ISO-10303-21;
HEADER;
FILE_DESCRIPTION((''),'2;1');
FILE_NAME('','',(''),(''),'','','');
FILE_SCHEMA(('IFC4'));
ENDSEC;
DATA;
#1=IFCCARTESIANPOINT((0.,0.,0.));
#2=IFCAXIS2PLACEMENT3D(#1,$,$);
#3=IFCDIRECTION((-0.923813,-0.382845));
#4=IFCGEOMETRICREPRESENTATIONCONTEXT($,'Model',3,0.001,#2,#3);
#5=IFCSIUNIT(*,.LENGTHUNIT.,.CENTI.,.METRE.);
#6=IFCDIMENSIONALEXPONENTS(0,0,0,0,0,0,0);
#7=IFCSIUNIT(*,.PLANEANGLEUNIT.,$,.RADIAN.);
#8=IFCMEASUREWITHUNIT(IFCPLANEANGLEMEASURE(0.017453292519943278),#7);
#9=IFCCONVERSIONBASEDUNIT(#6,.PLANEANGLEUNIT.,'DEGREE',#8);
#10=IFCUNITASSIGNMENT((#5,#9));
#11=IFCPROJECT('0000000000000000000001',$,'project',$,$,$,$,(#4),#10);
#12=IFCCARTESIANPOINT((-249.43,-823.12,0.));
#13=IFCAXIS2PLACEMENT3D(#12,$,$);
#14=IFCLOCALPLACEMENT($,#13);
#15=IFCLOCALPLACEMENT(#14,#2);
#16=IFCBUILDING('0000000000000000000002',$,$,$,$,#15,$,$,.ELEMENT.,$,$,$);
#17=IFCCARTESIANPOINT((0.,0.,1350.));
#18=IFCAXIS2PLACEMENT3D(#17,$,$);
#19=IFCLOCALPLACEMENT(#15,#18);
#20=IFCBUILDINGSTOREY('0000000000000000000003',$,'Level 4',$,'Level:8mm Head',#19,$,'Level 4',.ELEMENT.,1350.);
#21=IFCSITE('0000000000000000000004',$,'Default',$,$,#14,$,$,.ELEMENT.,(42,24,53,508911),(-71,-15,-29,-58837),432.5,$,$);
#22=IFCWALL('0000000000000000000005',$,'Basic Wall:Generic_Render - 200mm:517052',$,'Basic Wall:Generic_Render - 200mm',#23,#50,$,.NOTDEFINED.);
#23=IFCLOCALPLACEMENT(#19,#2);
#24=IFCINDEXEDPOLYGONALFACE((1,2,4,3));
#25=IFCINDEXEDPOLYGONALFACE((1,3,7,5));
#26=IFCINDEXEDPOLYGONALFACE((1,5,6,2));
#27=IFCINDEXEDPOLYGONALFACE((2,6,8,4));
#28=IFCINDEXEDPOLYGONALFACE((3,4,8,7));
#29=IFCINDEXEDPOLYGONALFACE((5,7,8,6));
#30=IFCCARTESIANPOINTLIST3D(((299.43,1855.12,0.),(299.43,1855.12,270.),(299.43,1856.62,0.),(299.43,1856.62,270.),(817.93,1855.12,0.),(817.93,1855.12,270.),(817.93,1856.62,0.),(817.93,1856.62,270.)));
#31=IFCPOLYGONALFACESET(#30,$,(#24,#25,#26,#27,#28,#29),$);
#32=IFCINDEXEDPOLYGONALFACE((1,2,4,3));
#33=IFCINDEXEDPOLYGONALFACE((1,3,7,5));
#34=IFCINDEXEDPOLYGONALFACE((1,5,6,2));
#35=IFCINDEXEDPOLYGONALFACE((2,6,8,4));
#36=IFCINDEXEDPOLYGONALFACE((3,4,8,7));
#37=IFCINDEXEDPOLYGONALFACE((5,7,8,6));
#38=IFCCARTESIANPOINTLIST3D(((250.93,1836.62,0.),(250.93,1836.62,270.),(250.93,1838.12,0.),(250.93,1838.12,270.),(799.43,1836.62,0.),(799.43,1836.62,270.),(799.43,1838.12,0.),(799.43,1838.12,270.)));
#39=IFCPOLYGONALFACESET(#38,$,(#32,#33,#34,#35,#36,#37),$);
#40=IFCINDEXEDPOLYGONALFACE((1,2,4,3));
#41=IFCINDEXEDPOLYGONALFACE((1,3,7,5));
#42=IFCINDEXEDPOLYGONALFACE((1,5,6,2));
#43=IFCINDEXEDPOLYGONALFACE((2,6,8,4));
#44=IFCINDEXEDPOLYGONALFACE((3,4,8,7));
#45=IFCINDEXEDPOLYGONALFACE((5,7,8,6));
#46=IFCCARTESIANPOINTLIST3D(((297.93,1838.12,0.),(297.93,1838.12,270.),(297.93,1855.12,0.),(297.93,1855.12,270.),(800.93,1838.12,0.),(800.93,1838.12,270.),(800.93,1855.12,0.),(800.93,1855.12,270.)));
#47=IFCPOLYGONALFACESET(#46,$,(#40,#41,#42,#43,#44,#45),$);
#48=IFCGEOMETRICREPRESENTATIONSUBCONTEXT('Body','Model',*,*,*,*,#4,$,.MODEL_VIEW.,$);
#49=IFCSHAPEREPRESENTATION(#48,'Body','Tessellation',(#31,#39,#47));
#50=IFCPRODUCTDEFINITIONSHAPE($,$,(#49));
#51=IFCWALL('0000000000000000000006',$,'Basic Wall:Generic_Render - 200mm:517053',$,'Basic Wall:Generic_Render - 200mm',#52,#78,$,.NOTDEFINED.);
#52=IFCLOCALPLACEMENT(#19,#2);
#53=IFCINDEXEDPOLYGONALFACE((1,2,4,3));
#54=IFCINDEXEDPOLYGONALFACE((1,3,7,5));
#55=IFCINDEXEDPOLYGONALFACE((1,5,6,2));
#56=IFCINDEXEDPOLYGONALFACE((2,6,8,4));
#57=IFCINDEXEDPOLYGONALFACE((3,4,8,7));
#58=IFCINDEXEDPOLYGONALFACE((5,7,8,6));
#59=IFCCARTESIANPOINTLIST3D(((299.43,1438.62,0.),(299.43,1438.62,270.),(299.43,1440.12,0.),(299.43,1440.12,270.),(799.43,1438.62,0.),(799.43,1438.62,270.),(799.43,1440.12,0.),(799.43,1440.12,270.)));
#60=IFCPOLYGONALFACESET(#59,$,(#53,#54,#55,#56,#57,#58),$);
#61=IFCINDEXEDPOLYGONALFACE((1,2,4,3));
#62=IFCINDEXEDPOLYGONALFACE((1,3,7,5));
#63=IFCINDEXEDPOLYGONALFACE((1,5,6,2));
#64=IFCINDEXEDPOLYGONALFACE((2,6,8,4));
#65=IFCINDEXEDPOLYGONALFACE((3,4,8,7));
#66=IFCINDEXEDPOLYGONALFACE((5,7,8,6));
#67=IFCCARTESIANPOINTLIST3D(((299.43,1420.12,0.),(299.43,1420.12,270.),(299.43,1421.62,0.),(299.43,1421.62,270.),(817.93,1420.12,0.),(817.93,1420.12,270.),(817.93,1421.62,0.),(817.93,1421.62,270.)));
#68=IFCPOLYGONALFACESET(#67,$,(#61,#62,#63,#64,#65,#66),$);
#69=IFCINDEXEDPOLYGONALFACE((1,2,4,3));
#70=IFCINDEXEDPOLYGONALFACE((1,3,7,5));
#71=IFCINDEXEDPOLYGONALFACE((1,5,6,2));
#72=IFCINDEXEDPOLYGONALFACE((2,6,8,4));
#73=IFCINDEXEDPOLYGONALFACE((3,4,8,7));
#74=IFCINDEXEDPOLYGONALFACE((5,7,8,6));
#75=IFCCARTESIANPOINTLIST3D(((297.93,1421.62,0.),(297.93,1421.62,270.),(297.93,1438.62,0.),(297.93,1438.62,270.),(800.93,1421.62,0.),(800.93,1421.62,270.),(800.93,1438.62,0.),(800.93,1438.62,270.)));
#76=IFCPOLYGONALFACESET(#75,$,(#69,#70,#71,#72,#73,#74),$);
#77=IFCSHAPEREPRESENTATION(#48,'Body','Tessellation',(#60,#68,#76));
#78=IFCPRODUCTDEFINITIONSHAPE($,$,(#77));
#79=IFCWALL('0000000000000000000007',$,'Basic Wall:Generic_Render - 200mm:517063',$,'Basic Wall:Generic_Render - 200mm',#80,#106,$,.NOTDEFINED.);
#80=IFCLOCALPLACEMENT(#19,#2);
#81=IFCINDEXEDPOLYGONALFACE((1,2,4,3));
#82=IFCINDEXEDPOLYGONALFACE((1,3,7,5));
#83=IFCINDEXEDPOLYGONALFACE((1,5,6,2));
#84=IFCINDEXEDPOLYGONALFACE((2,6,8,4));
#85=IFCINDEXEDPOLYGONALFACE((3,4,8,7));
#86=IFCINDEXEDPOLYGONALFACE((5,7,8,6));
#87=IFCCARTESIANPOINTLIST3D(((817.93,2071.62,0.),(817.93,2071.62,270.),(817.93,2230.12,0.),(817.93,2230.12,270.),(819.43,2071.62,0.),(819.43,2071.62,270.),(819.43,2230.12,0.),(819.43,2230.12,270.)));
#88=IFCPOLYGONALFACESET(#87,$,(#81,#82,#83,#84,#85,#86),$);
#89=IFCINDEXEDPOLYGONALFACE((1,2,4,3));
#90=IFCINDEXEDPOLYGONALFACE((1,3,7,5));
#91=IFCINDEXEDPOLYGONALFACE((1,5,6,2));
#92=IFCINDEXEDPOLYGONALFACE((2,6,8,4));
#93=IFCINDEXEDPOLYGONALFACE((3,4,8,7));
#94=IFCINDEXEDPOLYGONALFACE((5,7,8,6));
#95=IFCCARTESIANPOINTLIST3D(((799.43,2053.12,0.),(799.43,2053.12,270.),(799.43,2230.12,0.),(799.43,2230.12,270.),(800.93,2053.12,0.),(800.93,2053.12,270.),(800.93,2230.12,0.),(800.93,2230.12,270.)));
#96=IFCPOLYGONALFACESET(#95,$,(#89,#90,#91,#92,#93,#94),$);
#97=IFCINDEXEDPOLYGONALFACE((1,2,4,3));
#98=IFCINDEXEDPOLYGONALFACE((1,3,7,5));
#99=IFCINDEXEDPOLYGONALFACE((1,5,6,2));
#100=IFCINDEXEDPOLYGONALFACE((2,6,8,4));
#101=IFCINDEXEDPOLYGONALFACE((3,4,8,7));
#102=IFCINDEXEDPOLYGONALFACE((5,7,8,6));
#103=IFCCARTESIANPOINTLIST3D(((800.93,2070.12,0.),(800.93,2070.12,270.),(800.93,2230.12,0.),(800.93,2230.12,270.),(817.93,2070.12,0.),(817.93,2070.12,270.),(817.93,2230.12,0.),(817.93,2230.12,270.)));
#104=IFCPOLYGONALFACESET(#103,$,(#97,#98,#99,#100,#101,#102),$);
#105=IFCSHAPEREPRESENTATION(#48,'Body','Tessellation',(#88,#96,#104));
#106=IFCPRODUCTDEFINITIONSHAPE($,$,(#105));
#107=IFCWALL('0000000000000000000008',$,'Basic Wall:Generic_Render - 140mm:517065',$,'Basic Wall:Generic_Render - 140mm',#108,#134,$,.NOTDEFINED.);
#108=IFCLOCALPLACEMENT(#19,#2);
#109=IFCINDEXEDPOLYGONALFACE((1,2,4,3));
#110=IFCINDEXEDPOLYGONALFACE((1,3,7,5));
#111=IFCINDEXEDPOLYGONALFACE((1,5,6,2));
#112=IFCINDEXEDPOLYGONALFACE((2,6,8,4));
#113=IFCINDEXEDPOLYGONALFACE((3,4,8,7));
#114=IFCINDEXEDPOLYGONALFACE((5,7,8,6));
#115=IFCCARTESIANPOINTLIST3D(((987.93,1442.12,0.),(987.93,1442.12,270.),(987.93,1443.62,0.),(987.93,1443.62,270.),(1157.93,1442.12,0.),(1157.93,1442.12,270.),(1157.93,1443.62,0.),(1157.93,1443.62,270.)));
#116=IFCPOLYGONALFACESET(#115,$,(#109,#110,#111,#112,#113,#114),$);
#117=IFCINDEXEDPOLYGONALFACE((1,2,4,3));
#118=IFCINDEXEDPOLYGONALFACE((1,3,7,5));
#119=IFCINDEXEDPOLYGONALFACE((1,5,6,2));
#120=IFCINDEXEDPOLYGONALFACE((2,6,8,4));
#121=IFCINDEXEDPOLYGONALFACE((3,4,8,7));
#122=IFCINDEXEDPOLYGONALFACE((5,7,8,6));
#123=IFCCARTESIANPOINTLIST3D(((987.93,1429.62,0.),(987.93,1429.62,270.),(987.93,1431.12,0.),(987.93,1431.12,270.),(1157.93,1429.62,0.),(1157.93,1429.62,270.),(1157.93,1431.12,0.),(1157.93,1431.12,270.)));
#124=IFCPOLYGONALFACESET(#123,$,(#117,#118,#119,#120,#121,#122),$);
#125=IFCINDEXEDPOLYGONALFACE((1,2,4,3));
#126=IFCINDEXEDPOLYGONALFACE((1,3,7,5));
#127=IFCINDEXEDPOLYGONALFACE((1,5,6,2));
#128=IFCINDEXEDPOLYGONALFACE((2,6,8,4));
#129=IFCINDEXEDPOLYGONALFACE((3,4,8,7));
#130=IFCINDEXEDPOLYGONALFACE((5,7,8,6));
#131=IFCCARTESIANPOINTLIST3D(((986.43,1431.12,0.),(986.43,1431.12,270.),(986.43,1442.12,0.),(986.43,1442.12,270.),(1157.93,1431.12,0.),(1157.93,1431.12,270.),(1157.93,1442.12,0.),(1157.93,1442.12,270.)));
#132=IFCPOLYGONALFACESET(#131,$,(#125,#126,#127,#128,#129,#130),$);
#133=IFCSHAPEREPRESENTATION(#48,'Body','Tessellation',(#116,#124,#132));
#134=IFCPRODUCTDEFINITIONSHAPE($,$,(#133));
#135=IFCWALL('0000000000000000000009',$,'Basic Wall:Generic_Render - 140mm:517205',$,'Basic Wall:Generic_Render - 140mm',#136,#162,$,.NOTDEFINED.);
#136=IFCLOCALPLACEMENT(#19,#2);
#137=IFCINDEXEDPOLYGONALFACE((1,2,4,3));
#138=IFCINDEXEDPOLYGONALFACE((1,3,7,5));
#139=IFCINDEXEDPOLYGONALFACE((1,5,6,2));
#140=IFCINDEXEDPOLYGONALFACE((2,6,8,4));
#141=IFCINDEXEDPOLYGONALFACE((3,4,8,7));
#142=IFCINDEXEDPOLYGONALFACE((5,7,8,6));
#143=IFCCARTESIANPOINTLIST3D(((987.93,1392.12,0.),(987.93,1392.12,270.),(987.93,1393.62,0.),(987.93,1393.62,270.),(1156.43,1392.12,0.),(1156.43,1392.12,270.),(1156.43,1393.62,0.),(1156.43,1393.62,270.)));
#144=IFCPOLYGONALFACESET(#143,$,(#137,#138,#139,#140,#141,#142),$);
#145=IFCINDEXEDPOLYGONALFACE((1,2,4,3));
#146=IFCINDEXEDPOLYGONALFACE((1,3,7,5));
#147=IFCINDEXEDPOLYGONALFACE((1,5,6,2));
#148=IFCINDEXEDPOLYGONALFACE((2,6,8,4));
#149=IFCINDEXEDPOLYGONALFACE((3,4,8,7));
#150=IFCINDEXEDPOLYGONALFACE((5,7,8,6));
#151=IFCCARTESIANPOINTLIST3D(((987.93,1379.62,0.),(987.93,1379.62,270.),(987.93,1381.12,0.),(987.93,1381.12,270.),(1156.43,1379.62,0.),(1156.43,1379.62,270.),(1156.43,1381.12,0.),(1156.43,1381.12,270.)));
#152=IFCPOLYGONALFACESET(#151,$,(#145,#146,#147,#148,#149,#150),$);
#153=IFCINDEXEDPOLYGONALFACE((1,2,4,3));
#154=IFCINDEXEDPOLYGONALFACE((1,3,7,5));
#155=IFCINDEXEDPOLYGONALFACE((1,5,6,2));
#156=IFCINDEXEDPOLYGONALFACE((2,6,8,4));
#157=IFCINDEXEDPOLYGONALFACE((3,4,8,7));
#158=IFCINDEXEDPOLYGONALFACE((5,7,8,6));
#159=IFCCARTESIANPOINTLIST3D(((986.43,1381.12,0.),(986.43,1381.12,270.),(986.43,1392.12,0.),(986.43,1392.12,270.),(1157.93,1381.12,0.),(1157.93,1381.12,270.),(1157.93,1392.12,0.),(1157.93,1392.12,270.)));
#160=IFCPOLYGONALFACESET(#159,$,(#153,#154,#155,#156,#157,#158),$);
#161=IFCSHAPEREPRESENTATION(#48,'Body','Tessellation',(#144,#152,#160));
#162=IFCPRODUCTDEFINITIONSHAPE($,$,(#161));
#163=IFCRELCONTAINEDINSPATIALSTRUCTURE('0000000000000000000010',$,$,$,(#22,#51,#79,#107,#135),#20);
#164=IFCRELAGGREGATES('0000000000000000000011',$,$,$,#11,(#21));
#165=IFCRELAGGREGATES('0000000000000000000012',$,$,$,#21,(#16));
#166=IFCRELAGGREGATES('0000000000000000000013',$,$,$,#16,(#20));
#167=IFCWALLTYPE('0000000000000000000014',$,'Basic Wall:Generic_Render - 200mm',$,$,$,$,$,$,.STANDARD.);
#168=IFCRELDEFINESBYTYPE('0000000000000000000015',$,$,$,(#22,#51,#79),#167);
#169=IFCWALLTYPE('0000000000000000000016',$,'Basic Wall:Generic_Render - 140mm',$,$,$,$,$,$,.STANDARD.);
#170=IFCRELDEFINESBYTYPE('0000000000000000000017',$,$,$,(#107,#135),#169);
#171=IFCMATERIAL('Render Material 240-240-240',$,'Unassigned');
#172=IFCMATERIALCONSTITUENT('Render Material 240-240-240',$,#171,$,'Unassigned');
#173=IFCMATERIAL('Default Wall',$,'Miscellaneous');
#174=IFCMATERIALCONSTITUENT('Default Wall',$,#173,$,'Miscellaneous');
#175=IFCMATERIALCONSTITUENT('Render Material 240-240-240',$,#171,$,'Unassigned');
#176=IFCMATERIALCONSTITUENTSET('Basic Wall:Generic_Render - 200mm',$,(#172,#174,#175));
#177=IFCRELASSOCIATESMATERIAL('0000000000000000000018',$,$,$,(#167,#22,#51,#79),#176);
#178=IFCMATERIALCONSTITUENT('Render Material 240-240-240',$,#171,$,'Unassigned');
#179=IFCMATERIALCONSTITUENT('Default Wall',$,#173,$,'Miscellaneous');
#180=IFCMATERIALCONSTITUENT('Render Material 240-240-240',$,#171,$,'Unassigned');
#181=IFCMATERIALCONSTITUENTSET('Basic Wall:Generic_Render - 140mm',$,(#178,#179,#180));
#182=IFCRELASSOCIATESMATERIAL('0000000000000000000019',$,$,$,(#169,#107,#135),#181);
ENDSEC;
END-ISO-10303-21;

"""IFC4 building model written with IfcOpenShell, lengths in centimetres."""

from ifc_helpers import new_model, entity, si_unit, converted_unit, direction, frame, origin, place, context, subcontext, project, spatial, indexed_curve, outline, extrude, material, constituent, constituent_set, type_object, element, save


model = new_model("IFC4")

# Units and contexts
model_context = context("Model", 3, precision=0.001, world=origin(), true_north=direction((-0.923813, -0.382845)))
body_context = subcontext(model_context, "Body", "Model", "MODEL_VIEW")
ifc_project = project(units=[si_unit("LENGTHUNIT", "METRE", prefix="CENTI"), converted_unit("PLANEANGLEUNIT", "DEGREE", entity("IfcPlaneAngleMeasure", 0.017453292519943278), si_unit("PLANEANGLEUNIT", "RADIAN"), dimensions=[0, 0, 0, 0, 0, 0, 0])], contexts=[model_context])

# Site, building, storey
site_placement = place(None, frame((-249.43, -823.12, 0.0)))
site = spatial("IfcSite", under=ifc_project, at=site_placement, Name="Default", CompositionType="ELEMENT", RefLatitude=(42, 24, 53, 508911), RefLongitude=(-71, -15, -29, -58837), RefElevation=432.5)
building_placement = place(site_placement, origin())
building = spatial("IfcBuilding", under=site, at=building_placement, CompositionType="ELEMENT")
storey_placement = place(building_placement, frame((0.0, 0.0, 1350.0)))
storey = spatial("IfcBuildingStorey", under=building, at=storey_placement, Name="Level 4", ObjectType="Level:8mm Head", LongName="Level 4", CompositionType="ELEMENT", Elevation=1350.0)

# Shared definitions
ifc_material_1 = material(Name="Render Material 240-240-240", Category="Unassigned")
ifc_material_2 = material(Name="Default Wall", Category="Miscellaneous")

# Shared definitions
ifc_constituent_1 = constituent(ifc_material_1, Name="Render Material 240-240-240", Category="Unassigned")
ifc_constituent_2 = constituent(ifc_material_2, Name="Default Wall", Category="Miscellaneous")
ifc_constituent_3 = constituent(ifc_material_1, Name="Render Material 240-240-240", Category="Unassigned")
ifc_constituent_set_1 = constituent_set(constituents=[ifc_constituent_1, ifc_constituent_2, ifc_constituent_3], Name="Basic Wall:Generic_Render - 200mm")
wall_type_1 = type_object("IfcWallType", Name="Basic Wall:Generic_Render - 200mm", PredefinedType="STANDARD", material=ifc_constituent_set_1)

# Walls
wall_1_placement = place(storey_placement, frame((799.43, 1846.62, 0.0), z_axis=(0.0, 0.0, 1.0), x_axis=(-1.0, 0.0, 0.0)))
element("IfcWall", 1, at=wall_1_placement, inside=storey, type_object=wall_type_1, material=ifc_constituent_set_1, Name="Basic Wall:Generic_Render - 200mm:517052", ObjectType="Basic Wall:Generic_Render - 200mm", PredefinedType="NOTDEFINED", context=body_context, shape_type="SweptSolid", body=[
    extrude(outline(indexed_curve([(-0.75, -259.25), (0.75, -259.25), (0.75, 259.25), (-0.75, 259.25), (-0.75, -259.25)], self_intersect=False)), frame((240.75, -9.25, 0.0), z_axis=(0.0, 0.0, 1.0), x_axis=(0.0, 1.0, 0.0)), (0.0, 0.0, 1.0), 270.0),
    extrude(outline(indexed_curve([(-0.75, -274.25), (0.75, -274.25), (0.75, 274.25), (-0.75, 274.25), (-0.75, -274.25)], self_intersect=False)), frame((274.25, 9.25, 0.0), z_axis=(0.0, 0.0, 1.0), x_axis=(0.0, -1.0, 0.0)), (0.0, 0.0, 1.0), 270.0),
    extrude(outline(indexed_curve([(-251.5, -8.5), (251.5, -8.5), (251.5, 8.5), (-251.5, 8.5), (-251.5, -8.5)], self_intersect=False)), frame((250.0, 0.0, 0.0)), (0.0, 0.0, 1.0), 270.0),
])
wall_2_placement = place(storey_placement, frame((799.43, 1430.12, 0.0), z_axis=(0.0, 0.0, 1.0), x_axis=(-1.0, 0.0, 0.0)))
element("IfcWall", 2, at=wall_2_placement, inside=storey, type_object=wall_type_1, material=ifc_constituent_set_1, Name="Basic Wall:Generic_Render - 200mm:517053", ObjectType="Basic Wall:Generic_Render - 200mm", PredefinedType="NOTDEFINED", context=body_context, shape_type="SweptSolid", body=[
    extrude(outline(indexed_curve([(-0.75, -250.0), (0.75, -250.0), (0.75, 250.0), (-0.75, 250.0), (-0.75, -250.0)], self_intersect=False)), frame((250.0, -9.25, 0.0), z_axis=(0.0, 0.0, 1.0), x_axis=(0.0, 1.0, 0.0)), (0.0, 0.0, 1.0), 270.0),
    extrude(outline(indexed_curve([(-0.75, -259.25), (0.75, -259.25), (0.75, 259.25), (-0.75, 259.25), (-0.75, -259.25)], self_intersect=False)), frame((240.75, 9.25, 0.0), z_axis=(0.0, 0.0, 1.0), x_axis=(0.0, -1.0, 0.0)), (0.0, 0.0, 1.0), 270.0),
    extrude(outline(indexed_curve([(-251.5, -8.5), (251.5, -8.5), (251.5, 8.5), (-251.5, 8.5), (-251.5, -8.5)], self_intersect=False)), frame((250.0, 0.0, 0.0)), (0.0, 0.0, 1.0), 270.0),
])

# Walls
wall_3_placement = place(storey_placement, frame((809.43, 2071.62, 0.0), z_axis=(0.0, 0.0, 1.0), x_axis=(0.0, 1.0, 0.0)))
element("IfcWall", 3, at=wall_3_placement, inside=storey, type_object=wall_type_1, material=ifc_constituent_set_1, Name="Basic Wall:Generic_Render - 200mm:517063", ObjectType="Basic Wall:Generic_Render - 200mm", PredefinedType="NOTDEFINED", context=body_context, shape_type="SweptSolid", body=[
    extrude(outline(indexed_curve([(-0.75, -79.25), (0.75, -79.25), (0.75, 79.25), (-0.75, 79.25), (-0.75, -79.25)], self_intersect=False)), frame((79.25, -9.25, 0.0), z_axis=(0.0, 0.0, 1.0), x_axis=(0.0, 1.0, 0.0)), (0.0, 0.0, 1.0), 270.0),
    extrude(outline(indexed_curve([(-0.75, -88.5), (0.75, -88.5), (0.75, 88.5), (-0.75, 88.5), (-0.75, -88.5)], self_intersect=False)), frame((70.0, 9.25, 0.0), z_axis=(0.0, 0.0, 1.0), x_axis=(0.0, -1.0, 0.0)), (0.0, 0.0, 1.0), 270.0),
    extrude(outline(indexed_curve([(-80.0, -8.5), (80.0, -8.5), (80.0, 8.5), (-80.0, 8.5), (-80.0, -8.5)], self_intersect=False)), frame((78.5, 0.0, 0.0)), (0.0, 0.0, 1.0), 270.0),
])
ifc_constituent_4 = constituent(ifc_material_1, Name="Render Material 240-240-240", Category="Unassigned")
ifc_constituent_5 = constituent(ifc_material_2, Name="Default Wall", Category="Miscellaneous")
ifc_constituent_6 = constituent(ifc_material_1, Name="Render Material 240-240-240", Category="Unassigned")
ifc_constituent_set_2 = constituent_set(constituents=[ifc_constituent_4, ifc_constituent_5, ifc_constituent_6], Name="Basic Wall:Generic_Render - 140mm")
wall_type_2 = type_object("IfcWallType", Name="Basic Wall:Generic_Render - 140mm", PredefinedType="STANDARD", material=ifc_constituent_set_2)
wall_4_placement = place(storey_placement, frame((1157.93, 1436.62, 0.0), z_axis=(0.0, 0.0, 1.0), x_axis=(-1.0, 0.0, 0.0)))
element("IfcWall", 4, at=wall_4_placement, inside=storey, type_object=wall_type_2, material=ifc_constituent_set_2, Name="Basic Wall:Generic_Render - 140mm:517065", ObjectType="Basic Wall:Generic_Render - 140mm", PredefinedType="NOTDEFINED", context=body_context, shape_type="SweptSolid", body=[
    extrude(outline(indexed_curve([(-0.75, -85.0), (0.75, -85.0), (0.75, 85.0), (-0.75, 85.0), (-0.75, -85.0)], self_intersect=False)), frame((85.0, -6.25, 0.0), z_axis=(0.0, 0.0, 1.0), x_axis=(0.0, 1.0, 0.0)), (0.0, 0.0, 1.0), 270.0),
    extrude(outline(indexed_curve([(-0.75, -85.0), (0.75, -85.0), (0.75, 85.0), (-0.75, 85.0), (-0.75, -85.0)], self_intersect=False)), frame((85.0, 6.25, 0.0), z_axis=(0.0, 0.0, 1.0), x_axis=(0.0, -1.0, 0.0)), (0.0, 0.0, 1.0), 270.0),
    extrude(outline(indexed_curve([(-85.75, -5.5), (85.75, -5.5), (85.75, 5.5), (-85.75, 5.5), (-85.75, -5.5)], self_intersect=False)), frame((85.75, 0.0, 0.0)), (0.0, 0.0, 1.0), 270.0),
])
wall_5_placement = place(storey_placement, frame((1156.43, 1386.62, 0.0), z_axis=(0.0, 0.0, 1.0), x_axis=(-1.0, 0.0, 0.0)))
element("IfcWall", 5, at=wall_5_placement, inside=storey, type_object=wall_type_2, material=ifc_constituent_set_2, Name="Basic Wall:Generic_Render - 140mm:517205", ObjectType="Basic Wall:Generic_Render - 140mm", PredefinedType="NOTDEFINED", context=body_context, shape_type="SweptSolid", body=[
    extrude(outline(indexed_curve([(-0.75, -84.25), (0.75, -84.25), (0.75, 84.25), (-0.75, 84.25), (-0.75, -84.25)], self_intersect=False)), frame((84.25, -6.25, 0.0), z_axis=(0.0, 0.0, 1.0), x_axis=(0.0, 1.0, 0.0)), (0.0, 0.0, 1.0), 270.0),
    extrude(outline(indexed_curve([(-0.75, -84.25), (0.75, -84.25), (0.75, 84.25), (-0.75, 84.25), (-0.75, -84.25)], self_intersect=False)), frame((84.25, 6.25, 0.0), z_axis=(0.0, 0.0, 1.0), x_axis=(0.0, -1.0, 0.0)), (0.0, 0.0, 1.0), 270.0),
    extrude(outline(indexed_curve([(-85.75, -5.5), (85.75, -5.5), (85.75, 5.5), (-85.75, 5.5), (-85.75, -5.5)], self_intersect=False)), frame((84.25, 0.0, 0.0)), (0.0, 0.0, 1.0), 270.0),
])

save(model, "model.ifc")
